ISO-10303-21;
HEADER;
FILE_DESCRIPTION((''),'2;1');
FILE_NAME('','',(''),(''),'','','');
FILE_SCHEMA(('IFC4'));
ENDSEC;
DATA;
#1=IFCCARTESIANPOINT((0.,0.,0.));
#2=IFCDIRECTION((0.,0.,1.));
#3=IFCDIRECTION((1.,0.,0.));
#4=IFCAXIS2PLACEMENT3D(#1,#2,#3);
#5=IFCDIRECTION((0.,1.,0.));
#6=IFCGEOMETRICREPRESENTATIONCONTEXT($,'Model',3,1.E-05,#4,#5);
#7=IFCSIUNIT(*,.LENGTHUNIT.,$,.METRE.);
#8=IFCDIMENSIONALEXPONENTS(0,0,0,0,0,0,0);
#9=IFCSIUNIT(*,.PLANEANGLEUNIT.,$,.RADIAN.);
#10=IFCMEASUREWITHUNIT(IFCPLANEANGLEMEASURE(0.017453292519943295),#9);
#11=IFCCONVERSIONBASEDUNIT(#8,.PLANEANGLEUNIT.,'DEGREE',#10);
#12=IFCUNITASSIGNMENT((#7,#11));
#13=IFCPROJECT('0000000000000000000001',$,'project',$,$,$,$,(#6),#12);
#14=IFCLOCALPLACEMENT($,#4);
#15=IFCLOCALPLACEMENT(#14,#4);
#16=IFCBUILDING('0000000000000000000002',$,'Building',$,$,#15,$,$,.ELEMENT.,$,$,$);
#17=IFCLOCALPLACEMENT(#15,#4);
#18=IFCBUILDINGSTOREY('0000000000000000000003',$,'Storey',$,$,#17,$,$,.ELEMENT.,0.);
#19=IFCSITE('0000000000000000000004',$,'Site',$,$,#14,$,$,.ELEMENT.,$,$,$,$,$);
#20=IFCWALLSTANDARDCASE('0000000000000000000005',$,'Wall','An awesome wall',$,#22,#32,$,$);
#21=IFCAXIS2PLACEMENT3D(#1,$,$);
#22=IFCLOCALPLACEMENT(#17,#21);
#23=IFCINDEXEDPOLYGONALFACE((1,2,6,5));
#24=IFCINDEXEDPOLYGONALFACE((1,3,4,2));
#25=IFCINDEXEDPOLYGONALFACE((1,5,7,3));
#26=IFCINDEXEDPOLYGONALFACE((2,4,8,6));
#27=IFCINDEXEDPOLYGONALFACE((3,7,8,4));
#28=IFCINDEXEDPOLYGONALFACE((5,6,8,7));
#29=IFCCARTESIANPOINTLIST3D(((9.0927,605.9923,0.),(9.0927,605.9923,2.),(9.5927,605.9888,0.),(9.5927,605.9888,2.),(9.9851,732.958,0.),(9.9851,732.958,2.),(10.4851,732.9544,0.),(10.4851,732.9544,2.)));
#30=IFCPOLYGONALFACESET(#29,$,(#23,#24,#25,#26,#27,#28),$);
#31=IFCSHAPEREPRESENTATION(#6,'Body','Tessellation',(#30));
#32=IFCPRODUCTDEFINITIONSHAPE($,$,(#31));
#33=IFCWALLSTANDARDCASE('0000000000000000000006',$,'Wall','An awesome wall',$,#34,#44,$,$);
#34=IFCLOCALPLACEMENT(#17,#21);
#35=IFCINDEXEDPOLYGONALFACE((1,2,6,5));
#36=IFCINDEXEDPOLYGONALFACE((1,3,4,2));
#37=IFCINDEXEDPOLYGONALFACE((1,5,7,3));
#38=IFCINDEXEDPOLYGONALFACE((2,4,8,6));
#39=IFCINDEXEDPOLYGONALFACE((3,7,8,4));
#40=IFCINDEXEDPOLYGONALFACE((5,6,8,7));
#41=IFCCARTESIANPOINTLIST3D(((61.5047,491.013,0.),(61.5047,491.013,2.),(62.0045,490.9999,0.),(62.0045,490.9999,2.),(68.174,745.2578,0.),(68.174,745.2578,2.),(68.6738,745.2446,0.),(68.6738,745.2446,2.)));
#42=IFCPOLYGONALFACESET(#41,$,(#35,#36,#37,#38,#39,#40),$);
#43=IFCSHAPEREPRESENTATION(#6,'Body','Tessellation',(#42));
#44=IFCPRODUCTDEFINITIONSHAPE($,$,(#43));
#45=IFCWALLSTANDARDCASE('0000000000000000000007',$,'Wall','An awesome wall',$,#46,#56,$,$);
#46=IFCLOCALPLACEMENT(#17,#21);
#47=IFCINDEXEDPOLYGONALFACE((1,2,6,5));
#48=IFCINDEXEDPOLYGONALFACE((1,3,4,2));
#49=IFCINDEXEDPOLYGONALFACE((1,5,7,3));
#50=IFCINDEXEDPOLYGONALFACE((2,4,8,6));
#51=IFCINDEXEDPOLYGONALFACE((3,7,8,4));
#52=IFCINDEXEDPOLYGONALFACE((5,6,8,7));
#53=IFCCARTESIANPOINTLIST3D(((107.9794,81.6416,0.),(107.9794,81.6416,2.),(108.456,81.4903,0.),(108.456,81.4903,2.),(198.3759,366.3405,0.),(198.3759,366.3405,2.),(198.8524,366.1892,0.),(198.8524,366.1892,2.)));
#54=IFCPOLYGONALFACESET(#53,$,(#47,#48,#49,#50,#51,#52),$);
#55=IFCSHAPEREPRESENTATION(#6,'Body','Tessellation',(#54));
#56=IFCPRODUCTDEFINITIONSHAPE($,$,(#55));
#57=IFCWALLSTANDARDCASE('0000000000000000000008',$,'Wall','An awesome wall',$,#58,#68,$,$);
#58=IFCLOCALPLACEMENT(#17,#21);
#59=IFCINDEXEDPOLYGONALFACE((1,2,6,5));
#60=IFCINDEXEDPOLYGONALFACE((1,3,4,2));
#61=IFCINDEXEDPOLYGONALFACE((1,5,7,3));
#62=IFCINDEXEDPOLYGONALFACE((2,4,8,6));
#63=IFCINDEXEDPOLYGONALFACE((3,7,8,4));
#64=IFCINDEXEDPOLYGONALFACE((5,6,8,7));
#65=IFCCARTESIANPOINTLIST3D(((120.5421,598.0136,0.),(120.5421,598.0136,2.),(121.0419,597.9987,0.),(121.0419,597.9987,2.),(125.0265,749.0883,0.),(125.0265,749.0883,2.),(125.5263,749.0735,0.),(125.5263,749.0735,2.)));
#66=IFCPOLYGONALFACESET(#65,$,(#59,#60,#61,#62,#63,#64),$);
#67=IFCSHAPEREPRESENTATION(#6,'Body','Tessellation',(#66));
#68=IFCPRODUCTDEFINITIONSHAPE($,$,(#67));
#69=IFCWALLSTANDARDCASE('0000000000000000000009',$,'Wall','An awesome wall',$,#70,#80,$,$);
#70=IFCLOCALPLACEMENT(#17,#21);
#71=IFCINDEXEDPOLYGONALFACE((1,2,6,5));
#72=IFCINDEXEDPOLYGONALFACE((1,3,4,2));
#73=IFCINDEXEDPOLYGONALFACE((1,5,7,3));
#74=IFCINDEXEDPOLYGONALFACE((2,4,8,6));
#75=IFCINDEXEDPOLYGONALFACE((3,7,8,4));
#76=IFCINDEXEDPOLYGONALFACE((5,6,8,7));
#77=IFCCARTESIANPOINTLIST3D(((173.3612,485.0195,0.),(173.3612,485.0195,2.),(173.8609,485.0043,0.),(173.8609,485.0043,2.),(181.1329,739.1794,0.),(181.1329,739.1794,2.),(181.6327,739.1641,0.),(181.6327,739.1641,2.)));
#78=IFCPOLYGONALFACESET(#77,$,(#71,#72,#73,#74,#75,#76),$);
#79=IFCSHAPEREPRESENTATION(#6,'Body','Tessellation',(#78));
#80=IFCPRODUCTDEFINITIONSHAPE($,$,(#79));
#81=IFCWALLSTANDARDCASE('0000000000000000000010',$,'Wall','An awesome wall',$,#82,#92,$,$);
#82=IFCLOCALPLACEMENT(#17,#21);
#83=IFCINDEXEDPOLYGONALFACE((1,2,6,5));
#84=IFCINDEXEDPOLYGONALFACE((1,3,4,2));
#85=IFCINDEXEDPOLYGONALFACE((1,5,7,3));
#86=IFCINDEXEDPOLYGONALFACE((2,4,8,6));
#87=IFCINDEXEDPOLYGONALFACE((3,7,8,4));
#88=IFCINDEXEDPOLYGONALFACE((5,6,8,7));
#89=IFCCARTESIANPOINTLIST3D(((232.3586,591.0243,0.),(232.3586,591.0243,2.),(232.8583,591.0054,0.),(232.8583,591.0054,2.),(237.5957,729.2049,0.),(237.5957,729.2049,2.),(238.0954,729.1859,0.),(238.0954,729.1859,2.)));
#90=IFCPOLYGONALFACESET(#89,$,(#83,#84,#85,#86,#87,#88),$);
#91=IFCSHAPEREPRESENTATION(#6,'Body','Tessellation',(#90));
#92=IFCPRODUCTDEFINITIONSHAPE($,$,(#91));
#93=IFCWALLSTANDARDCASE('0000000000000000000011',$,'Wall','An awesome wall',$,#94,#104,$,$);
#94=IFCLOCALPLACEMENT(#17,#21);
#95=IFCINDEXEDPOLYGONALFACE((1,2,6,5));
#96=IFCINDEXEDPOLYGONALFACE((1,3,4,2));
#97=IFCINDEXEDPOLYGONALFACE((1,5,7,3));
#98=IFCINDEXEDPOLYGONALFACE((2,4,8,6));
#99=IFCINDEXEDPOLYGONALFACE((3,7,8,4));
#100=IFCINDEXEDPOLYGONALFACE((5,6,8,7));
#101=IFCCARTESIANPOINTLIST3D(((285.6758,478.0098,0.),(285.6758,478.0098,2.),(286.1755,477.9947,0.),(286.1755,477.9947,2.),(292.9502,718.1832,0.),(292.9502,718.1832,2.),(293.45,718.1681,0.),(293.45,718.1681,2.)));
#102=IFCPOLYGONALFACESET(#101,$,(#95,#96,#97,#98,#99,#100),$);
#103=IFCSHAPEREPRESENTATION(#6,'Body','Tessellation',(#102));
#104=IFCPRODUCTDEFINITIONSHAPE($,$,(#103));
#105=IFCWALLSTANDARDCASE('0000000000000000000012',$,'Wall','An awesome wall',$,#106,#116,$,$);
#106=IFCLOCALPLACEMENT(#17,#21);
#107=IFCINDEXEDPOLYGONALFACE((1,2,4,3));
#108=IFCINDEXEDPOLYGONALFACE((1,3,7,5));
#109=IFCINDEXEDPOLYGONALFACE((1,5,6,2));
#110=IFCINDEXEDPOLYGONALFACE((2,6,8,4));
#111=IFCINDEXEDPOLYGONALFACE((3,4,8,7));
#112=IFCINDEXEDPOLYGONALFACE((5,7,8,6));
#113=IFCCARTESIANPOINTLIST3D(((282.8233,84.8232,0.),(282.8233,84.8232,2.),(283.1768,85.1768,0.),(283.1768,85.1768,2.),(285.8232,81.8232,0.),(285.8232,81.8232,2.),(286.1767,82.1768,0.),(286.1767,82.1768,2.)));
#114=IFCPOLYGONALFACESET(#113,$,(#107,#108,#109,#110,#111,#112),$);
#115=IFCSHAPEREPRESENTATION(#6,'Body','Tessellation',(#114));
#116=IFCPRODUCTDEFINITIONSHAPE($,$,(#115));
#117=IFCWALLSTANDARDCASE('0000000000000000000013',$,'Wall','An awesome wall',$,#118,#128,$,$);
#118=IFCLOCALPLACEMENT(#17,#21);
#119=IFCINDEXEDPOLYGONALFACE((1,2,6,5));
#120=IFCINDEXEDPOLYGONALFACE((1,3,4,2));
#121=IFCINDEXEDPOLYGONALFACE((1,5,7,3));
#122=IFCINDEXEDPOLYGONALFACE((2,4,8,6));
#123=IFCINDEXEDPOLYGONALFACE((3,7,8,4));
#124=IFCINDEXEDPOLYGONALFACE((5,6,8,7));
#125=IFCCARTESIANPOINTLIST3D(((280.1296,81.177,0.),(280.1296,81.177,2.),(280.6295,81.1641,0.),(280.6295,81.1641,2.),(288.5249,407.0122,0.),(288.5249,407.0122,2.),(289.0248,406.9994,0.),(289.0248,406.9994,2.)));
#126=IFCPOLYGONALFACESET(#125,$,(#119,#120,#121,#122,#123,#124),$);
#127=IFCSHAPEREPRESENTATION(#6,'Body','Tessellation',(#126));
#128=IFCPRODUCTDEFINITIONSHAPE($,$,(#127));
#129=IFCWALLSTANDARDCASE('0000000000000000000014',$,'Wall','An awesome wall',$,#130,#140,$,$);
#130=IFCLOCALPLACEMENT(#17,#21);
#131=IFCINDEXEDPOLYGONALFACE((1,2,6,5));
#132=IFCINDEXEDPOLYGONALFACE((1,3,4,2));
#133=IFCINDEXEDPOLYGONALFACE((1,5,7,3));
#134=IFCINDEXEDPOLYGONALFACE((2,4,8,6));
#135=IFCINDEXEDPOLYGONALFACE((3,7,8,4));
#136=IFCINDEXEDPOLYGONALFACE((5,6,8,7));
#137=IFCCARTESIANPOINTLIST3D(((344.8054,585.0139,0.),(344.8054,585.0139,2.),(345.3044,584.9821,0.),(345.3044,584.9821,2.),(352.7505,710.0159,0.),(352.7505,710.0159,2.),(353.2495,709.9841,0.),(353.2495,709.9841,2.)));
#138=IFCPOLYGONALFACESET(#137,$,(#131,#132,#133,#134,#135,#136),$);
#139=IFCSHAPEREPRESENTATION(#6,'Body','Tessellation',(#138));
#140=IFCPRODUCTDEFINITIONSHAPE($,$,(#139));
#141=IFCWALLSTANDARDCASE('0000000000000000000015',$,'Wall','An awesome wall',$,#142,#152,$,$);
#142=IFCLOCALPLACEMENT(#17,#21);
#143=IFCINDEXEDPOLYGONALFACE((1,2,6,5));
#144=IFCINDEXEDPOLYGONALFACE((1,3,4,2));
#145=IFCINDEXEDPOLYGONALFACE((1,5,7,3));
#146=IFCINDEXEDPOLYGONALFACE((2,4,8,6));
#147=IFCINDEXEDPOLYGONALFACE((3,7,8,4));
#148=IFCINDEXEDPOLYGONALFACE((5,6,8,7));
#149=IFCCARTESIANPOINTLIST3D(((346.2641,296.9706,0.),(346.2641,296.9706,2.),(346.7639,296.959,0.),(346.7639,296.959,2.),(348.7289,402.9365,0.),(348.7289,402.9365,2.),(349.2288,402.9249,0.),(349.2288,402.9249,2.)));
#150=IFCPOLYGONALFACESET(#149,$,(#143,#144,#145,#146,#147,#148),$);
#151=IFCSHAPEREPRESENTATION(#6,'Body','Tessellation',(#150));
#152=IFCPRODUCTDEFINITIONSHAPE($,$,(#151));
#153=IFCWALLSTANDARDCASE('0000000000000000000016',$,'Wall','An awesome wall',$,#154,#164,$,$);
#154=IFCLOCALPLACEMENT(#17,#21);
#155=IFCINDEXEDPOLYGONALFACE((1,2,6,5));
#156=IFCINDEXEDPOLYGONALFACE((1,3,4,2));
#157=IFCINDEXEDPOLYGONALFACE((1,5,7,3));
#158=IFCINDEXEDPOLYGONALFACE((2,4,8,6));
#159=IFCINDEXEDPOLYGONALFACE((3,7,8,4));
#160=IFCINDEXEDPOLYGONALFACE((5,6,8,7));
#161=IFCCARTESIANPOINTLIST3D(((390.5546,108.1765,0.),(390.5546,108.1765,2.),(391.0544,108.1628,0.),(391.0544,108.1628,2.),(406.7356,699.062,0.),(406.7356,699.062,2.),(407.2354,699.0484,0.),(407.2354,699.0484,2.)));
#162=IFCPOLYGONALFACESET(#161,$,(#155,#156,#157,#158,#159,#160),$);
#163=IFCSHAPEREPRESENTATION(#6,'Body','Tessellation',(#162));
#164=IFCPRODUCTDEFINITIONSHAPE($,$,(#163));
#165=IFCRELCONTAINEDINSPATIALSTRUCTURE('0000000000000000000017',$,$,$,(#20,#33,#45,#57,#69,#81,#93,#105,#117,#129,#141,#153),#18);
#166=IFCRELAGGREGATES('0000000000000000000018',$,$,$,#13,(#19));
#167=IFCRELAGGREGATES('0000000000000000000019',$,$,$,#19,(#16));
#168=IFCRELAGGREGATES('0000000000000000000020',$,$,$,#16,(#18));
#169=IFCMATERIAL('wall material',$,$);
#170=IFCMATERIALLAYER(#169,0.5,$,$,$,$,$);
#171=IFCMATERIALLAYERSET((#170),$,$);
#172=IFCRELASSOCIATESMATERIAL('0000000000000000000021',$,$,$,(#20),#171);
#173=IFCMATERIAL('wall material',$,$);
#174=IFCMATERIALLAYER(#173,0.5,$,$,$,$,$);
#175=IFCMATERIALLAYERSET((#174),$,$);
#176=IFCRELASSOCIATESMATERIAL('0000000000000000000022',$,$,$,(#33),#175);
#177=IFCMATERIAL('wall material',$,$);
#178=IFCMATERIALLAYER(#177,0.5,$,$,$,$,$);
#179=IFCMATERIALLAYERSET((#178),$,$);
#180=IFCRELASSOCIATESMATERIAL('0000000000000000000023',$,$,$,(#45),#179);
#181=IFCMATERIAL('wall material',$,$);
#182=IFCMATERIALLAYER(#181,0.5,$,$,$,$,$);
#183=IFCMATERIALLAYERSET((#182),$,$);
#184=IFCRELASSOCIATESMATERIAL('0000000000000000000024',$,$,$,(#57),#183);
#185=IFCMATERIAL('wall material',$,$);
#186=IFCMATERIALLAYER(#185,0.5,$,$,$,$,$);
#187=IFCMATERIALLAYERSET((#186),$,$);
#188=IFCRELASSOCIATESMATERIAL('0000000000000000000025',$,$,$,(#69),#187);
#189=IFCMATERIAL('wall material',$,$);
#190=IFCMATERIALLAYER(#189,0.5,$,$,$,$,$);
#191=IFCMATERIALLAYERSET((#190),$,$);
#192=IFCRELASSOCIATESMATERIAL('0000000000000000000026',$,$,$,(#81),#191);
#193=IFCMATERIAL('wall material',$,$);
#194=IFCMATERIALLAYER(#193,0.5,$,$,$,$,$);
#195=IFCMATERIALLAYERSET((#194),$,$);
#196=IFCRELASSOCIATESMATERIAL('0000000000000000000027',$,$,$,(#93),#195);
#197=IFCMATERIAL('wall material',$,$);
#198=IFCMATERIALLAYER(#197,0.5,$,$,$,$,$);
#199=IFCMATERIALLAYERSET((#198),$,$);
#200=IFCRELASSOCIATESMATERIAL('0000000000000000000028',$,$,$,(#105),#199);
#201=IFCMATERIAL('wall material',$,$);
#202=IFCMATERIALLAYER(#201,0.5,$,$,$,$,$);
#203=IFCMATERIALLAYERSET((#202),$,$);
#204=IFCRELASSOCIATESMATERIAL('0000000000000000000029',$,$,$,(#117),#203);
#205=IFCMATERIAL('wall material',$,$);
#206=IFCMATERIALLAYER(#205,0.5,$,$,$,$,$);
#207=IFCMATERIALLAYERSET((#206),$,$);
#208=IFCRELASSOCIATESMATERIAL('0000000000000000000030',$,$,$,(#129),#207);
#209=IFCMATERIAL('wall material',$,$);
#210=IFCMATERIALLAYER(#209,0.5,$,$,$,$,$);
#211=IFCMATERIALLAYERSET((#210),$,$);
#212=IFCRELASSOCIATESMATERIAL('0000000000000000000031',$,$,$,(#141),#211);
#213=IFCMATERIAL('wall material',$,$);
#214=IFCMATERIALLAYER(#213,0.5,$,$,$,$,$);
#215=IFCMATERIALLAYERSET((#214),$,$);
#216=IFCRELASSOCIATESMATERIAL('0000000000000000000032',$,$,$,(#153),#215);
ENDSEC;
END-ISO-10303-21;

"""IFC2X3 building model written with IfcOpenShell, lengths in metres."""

from ifc_helpers import new_model, entity, si_unit, converted_unit, direction, frame, origin_with_axes, place, context, project, spatial, polyline, outline, extrude, material, layer, layer_set, layer_usage, element, save


model = new_model("IFC2X3")

# Units and contexts
model_context = context("Model", 3, precision=1e-05, world=origin_with_axes(), true_north=direction((0.0, 1.0, 0.0)))
ifc_project = project(units=[si_unit("LENGTHUNIT", "METRE"), converted_unit("PLANEANGLEUNIT", "DEGREE", entity("IfcPlaneAngleMeasure", 0.017453292519943295), si_unit("PLANEANGLEUNIT", "RADIAN"), dimensions=[0, 0, 0, 0, 0, 0, 0])], contexts=[model_context])

# Site, building, storey
site_placement = place(None, origin_with_axes())
site = spatial("IfcSite", under=ifc_project, at=site_placement, Name="Site", CompositionType="ELEMENT")
building_placement = place(site_placement, origin_with_axes())
building = spatial("IfcBuilding", under=site, at=building_placement, Name="Building", CompositionType="ELEMENT")
storey_placement = place(building_placement, origin_with_axes())
storey = spatial("IfcBuildingStorey", under=building, at=storey_placement, Name="Storey", CompositionType="ELEMENT", Elevation=0.0)

# Walls
ifc_material_1 = material(Name="wall material")
ifc_layer_1 = layer(ifc_material_1, 0.5)
ifc_layer_set_1 = layer_set([ifc_layer_1])
ifc_layer_usage_1 = layer_usage(ifc_layer_set_1, "AXIS2", "POSITIVE", -0.1)
wall_1_placement = place(storey_placement, origin_with_axes())
element("IfcWallStandardCase", 1, at=wall_1_placement, inside=storey, material=ifc_layer_usage_1, Name="Wall", Description="An awesome wall", context=model_context, shape_type="SweptSolid", body=[
    extrude(outline(polyline([(0.0, -0.25, 0.0), (126.9688, -0.25, 0.0), (126.9688, 0.25, 0.0), (0.0, 0.25, 0.0), (0.0, -0.25, 0.0)])), frame((9.3427, 605.9905, 0.0), z_axis=(0.0, 0.0, 1.0), x_axis=(0.892388, 126.96566, 0.0)), (0.0, 0.0, 1.0), 2.0),
])
ifc_material_2 = material(Name="wall material")
ifc_layer_2 = layer(ifc_material_2, 0.5)
ifc_layer_set_2 = layer_set([ifc_layer_2])
ifc_layer_usage_2 = layer_usage(ifc_layer_set_2, "AXIS2", "POSITIVE", -0.1)
wall_2_placement = place(storey_placement, origin_with_axes())
element("IfcWallStandardCase", 2, at=wall_2_placement, inside=storey, material=ifc_layer_usage_2, Name="Wall", Description="An awesome wall", context=model_context, shape_type="SweptSolid", body=[
    extrude(outline(polyline([(0.0, -0.25, 0.0), (254.3322, -0.25, 0.0), (254.3322, 0.25, 0.0), (0.0, 0.25, 0.0), (0.0, -0.25, 0.0)])), frame((61.7546, 491.0064, 0.0), z_axis=(0.0, 0.0, 1.0), x_axis=(6.669304, 254.24476, 0.0)), (0.0, 0.0, 1.0), 2.0),
])
ifc_material_3 = material(Name="wall material")
ifc_layer_3 = layer(ifc_material_3, 0.5)
ifc_layer_set_3 = layer_set([ifc_layer_3])
ifc_layer_usage_3 = layer_usage(ifc_layer_set_3, "AXIS2", "POSITIVE", -0.1)
wall_3_placement = place(storey_placement, origin_with_axes())
element("IfcWallStandardCase", 3, at=wall_3_placement, inside=storey, material=ifc_layer_usage_3, Name="Wall", Description="An awesome wall", context=model_context, shape_type="SweptSolid", body=[
    extrude(outline(polyline([(0.0, -0.25, 0.0), (298.7056, -0.25, 0.0), (298.7056, 0.25, 0.0), (0.0, 0.25, 0.0), (0.0, -0.25, 0.0)])), frame((108.2177, 81.5659, 0.0), z_axis=(0.0, 0.0, 1.0), x_axis=(90.396466, 284.69894, 0.0)), (0.0, 0.0, 1.0), 2.0),
])
ifc_material_4 = material(Name="wall material")
ifc_layer_4 = layer(ifc_material_4, 0.5)
ifc_layer_set_4 = layer_set([ifc_layer_4])
ifc_layer_usage_4 = layer_usage(ifc_layer_set_4, "AXIS2", "POSITIVE", -0.1)
wall_4_placement = place(storey_placement, origin_with_axes())
element("IfcWallStandardCase", 4, at=wall_4_placement, inside=storey, material=ifc_layer_usage_4, Name="Wall", Description="An awesome wall", context=model_context, shape_type="SweptSolid", body=[
    extrude(outline(polyline([(0.0, -0.25, 0.0), (151.1413, -0.25, 0.0), (151.1413, 0.25, 0.0), (0.0, 0.25, 0.0), (0.0, -0.25, 0.0)])), frame((120.792, 598.0062, 0.0), z_axis=(0.0, 0.0, 1.0), x_axis=(4.484415, 151.07474, 0.0)), (0.0, 0.0, 1.0), 2.0),
])
ifc_material_5 = material(Name="wall material")
ifc_layer_5 = layer(ifc_material_5, 0.5)
ifc_layer_set_5 = layer_set([ifc_layer_5])
ifc_layer_usage_5 = layer_usage(ifc_layer_set_5, "AXIS2", "POSITIVE", -0.1)
wall_5_placement = place(storey_placement, origin_with_axes())
element("IfcWallStandardCase", 5, at=wall_5_placement, inside=storey, material=ifc_layer_usage_5, Name="Wall", Description="An awesome wall", context=model_context, shape_type="SweptSolid", body=[
    extrude(outline(polyline([(0.0, -0.25, 0.0), (254.2786, -0.25, 0.0), (254.2786, 0.25, 0.0), (0.0, 0.25, 0.0), (0.0, -0.25, 0.0)])), frame((173.611, 485.0119, 0.0), z_axis=(0.0, 0.0, 1.0), x_axis=(7.77176, 254.15985, 0.0)), (0.0, 0.0, 1.0), 2.0),
])
ifc_material_6 = material(Name="wall material")
ifc_layer_6 = layer(ifc_material_6, 0.5)
ifc_layer_set_6 = layer_set([ifc_layer_6])
ifc_layer_usage_6 = layer_usage(ifc_layer_set_6, "AXIS2", "POSITIVE", -0.1)
wall_6_placement = place(storey_placement, origin_with_axes())
element("IfcWallStandardCase", 6, at=wall_6_placement, inside=storey, material=ifc_layer_usage_6, Name="Wall", Description="An awesome wall", context=model_context, shape_type="SweptSolid", body=[
    extrude(outline(polyline([(0.0, -0.25, 0.0), (138.2798, -0.25, 0.0), (138.2798, 0.25, 0.0), (0.0, 0.25, 0.0), (0.0, -0.25, 0.0)])), frame((232.6085, 591.0148, 0.0), z_axis=(0.0, 0.0, 1.0), x_axis=(5.23707, 138.18057, 0.0)), (0.0, 0.0, 1.0), 2.0),
])
ifc_material_7 = material(Name="wall material")
ifc_layer_7 = layer(ifc_material_7, 0.5)
ifc_layer_set_7 = layer_set([ifc_layer_7])
ifc_layer_usage_7 = layer_usage(ifc_layer_set_7, "AXIS2", "POSITIVE", -0.1)
wall_7_placement = place(storey_placement, origin_with_axes())
element("IfcWallStandardCase", 7, at=wall_7_placement, inside=storey, material=ifc_layer_usage_7, Name="Wall", Description="An awesome wall", context=model_context, shape_type="SweptSolid", body=[
    extrude(outline(polyline([(0.0, -0.25, 0.0), (240.2835, -0.25, 0.0), (240.2835, 0.25, 0.0), (0.0, 0.25, 0.0), (0.0, -0.25, 0.0)])), frame((285.9257, 478.0023, 0.0), z_axis=(0.0, 0.0, 1.0), x_axis=(7.27444, 240.1734, 0.0)), (0.0, 0.0, 1.0), 2.0),
])
ifc_material_8 = material(Name="wall material")
ifc_layer_8 = layer(ifc_material_8, 0.5)
ifc_layer_set_8 = layer_set([ifc_layer_8])
ifc_layer_usage_8 = layer_usage(ifc_layer_set_8, "AXIS2", "POSITIVE", -0.1)
wall_8_placement = place(storey_placement, origin_with_axes())
element("IfcWallStandardCase", 8, at=wall_8_placement, inside=storey, material=ifc_layer_usage_8, Name="Wall", Description="An awesome wall", context=model_context, shape_type="SweptSolid", body=[
    extrude(outline(polyline([(0.0, -0.25, 0.0), (4.2426, -0.25, 0.0), (4.2426, 0.25, 0.0), (0.0, 0.25, 0.0), (0.0, -0.25, 0.0)])), frame((286.0, 82.0, 0.0), z_axis=(0.0, 0.0, 1.0), x_axis=(-2.99994, 3.00003, 0.0)), (0.0, 0.0, 1.0), 2.0),
])
ifc_material_9 = material(Name="wall material")
ifc_layer_9 = layer(ifc_material_9, 0.5)
ifc_layer_set_9 = layer_set([ifc_layer_9])
ifc_layer_usage_9 = layer_usage(ifc_layer_set_9, "AXIS2", "POSITIVE", -0.1)
wall_9_placement = place(storey_placement, origin_with_axes())
element("IfcWallStandardCase", 9, at=wall_9_placement, inside=storey, material=ifc_layer_usage_9, Name="Wall", Description="An awesome wall", context=model_context, shape_type="SweptSolid", body=[
    extrude(outline(polyline([(0.0, -0.25, 0.0), (325.9434, -0.25, 0.0), (325.9434, 0.25, 0.0), (0.0, 0.25, 0.0), (0.0, -0.25, 0.0)])), frame((288.7748, 407.0058, 0.0), z_axis=(0.0, 0.0, 1.0), x_axis=(-8.39529, -325.83522, 0.0)), (0.0, 0.0, 1.0), 2.0),
])
ifc_material_10 = material(Name="wall material")
ifc_layer_10 = layer(ifc_material_10, 0.5)
ifc_layer_set_10 = layer_set([ifc_layer_10])
ifc_layer_usage_10 = layer_usage(ifc_layer_set_10, "AXIS2", "POSITIVE", -0.1)
wall_10_placement = place(storey_placement, origin_with_axes())
element("IfcWallStandardCase", 10, at=wall_10_placement, inside=storey, material=ifc_layer_usage_10, Name="Wall", Description="An awesome wall", context=model_context, shape_type="SweptSolid", body=[
    extrude(outline(polyline([(0.0, -0.25, 0.0), (125.2542, -0.25, 0.0), (125.2542, 0.25, 0.0), (0.0, 0.25, 0.0), (0.0, -0.25, 0.0)])), frame((345.0549, 584.998, 0.0), z_axis=(0.0, 0.0, 1.0), x_axis=(7.94513, 125.002, 0.0)), (0.0, 0.0, 1.0), 2.0),
])
ifc_material_11 = material(Name="wall material")
ifc_layer_11 = layer(ifc_material_11, 0.5)
ifc_layer_set_11 = layer_set([ifc_layer_11])
ifc_layer_usage_11 = layer_usage(ifc_layer_set_11, "AXIS2", "POSITIVE", -0.1)
wall_11_placement = place(storey_placement, origin_with_axes())
element("IfcWallStandardCase", 11, at=wall_11_placement, inside=storey, material=ifc_layer_usage_11, Name="Wall", Description="An awesome wall", context=model_context, shape_type="SweptSolid", body=[
    extrude(outline(polyline([(0.0, -0.25, 0.0), (105.9946, -0.25, 0.0), (105.9946, 0.25, 0.0), (0.0, 0.25, 0.0), (0.0, -0.25, 0.0)])), frame((346.514, 296.9648, 0.0), z_axis=(0.0, 0.0, 1.0), x_axis=(2.46485, 105.96592, 0.0)), (0.0, 0.0, 1.0), 2.0),
])
ifc_material_12 = material(Name="wall material")
ifc_layer_12 = layer(ifc_material_12, 0.5)
ifc_layer_set_12 = layer_set([ifc_layer_12])
ifc_layer_usage_12 = layer_usage(ifc_layer_set_12, "AXIS2", "POSITIVE", -0.1)
wall_12_placement = place(storey_placement, origin_with_axes())
element("IfcWallStandardCase", 12, at=wall_12_placement, inside=storey, material=ifc_layer_usage_12, Name="Wall", Description="An awesome wall", context=model_context, shape_type="SweptSolid", body=[
    extrude(outline(polyline([(0.0, -0.25, 0.0), (591.1071, -0.25, 0.0), (591.1071, 0.25, 0.0), (0.0, 0.25, 0.0), (0.0, -0.25, 0.0)])), frame((390.8045, 108.1697, 0.0), z_axis=(0.0, 0.0, 1.0), x_axis=(16.18097, 590.88554, 0.0)), (0.0, 0.0, 1.0), 2.0),
])

save(model, "model.ifc")
